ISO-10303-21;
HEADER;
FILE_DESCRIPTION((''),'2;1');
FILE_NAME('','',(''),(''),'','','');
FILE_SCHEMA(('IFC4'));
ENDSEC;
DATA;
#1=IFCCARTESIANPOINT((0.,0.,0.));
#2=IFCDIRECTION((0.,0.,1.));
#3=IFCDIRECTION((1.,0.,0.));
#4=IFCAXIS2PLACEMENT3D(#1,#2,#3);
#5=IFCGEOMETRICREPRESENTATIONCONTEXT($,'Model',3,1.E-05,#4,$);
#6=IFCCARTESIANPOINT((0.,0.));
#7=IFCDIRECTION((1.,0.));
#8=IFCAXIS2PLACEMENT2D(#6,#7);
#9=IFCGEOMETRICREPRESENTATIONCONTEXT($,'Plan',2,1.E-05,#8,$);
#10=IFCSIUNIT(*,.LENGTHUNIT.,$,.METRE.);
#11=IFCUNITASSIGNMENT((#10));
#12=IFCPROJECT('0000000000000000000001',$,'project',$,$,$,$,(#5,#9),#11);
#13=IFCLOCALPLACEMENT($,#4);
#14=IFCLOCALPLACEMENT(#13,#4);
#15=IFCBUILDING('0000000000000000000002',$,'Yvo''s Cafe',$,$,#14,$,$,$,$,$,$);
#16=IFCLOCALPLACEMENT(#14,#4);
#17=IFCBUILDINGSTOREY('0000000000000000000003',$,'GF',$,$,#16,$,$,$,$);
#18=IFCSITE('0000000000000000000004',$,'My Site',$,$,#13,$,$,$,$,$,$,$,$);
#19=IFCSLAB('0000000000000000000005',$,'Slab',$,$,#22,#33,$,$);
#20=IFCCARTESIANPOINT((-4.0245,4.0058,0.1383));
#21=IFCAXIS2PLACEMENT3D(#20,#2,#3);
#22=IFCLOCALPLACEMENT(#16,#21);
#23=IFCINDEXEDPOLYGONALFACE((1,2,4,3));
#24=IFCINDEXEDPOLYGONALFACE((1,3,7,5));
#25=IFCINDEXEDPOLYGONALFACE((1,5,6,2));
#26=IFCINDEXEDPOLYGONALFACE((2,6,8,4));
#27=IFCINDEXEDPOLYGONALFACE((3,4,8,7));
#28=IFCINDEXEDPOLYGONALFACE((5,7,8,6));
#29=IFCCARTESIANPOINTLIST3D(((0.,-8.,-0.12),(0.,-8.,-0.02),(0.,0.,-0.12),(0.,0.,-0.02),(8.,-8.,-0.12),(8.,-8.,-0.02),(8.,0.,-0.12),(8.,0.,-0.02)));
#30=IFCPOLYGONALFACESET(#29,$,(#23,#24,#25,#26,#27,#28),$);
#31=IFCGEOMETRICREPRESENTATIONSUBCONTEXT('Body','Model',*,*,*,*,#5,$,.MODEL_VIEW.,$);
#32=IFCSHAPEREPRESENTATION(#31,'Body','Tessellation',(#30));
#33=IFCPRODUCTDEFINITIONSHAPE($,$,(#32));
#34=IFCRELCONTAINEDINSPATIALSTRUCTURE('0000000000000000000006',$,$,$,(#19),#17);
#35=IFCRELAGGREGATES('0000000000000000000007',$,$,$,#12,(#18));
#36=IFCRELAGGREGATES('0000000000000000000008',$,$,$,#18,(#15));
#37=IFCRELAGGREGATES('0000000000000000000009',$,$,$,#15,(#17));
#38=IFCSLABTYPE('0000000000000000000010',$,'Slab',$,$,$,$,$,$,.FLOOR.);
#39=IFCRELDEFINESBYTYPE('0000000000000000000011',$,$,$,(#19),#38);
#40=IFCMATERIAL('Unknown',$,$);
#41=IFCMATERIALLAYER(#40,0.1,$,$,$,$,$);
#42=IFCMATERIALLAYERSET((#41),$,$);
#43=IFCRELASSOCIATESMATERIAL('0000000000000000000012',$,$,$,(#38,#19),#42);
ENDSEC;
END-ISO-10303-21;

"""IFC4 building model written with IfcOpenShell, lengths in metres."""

from ifc_helpers import new_model, si_unit, frame, origin_with_axes, origin_2d_with_axis, place, context, subcontext, project, spatial, indexed_curve, outline, extrude, material, layer, layer_set, layer_usage, type_object, element, save


model = new_model("IFC4")

# Units and contexts
model_context = context("Model", 3, precision=1e-05, world=origin_with_axes())
plan_context = context("Plan", 2, precision=1e-05, world=origin_2d_with_axis())
body_context_1 = subcontext(model_context, "Body", "Model", "MODEL_VIEW")
ifc_project = project(units=[si_unit("LENGTHUNIT", "METRE")], contexts=[model_context, plan_context])

# Site, building, storey
site_placement = place(None, origin_with_axes())
site = spatial("IfcSite", under=ifc_project, at=site_placement, Name="My Site")
building_placement = place(site_placement, origin_with_axes())
building = spatial("IfcBuilding", under=site, at=building_placement, Name="Yvo's Cafe")
storey_placement = place(building_placement, origin_with_axes())
storey = spatial("IfcBuildingStorey", under=building, at=storey_placement, Name="GF")

# Shared definitions
ifc_material = material(Name="Unknown")

# Slab
ifc_layer_1 = layer(ifc_material, 0.1)
ifc_layer_set_1 = layer_set([ifc_layer_1])
ifc_layer_usage_1 = layer_usage(ifc_layer_set_1, "AXIS3", "POSITIVE", -0.12)
slab_type = type_object("IfcSlabType", Name="Slab", PredefinedType="FLOOR", material=ifc_layer_set_1)
slab_placement = place(storey_placement, frame((-4.0245, 4.0058, 0.1383), z_axis=(0.0, 0.0, 1.0), x_axis=(1.0, 0.0, 0.0)))
element("IfcSlab", 1, at=slab_placement, inside=storey, type_object=slab_type, material=ifc_layer_usage_1, Name="Slab", context=body_context_1, shape_type="SweptSolid", body=[
    extrude(outline(indexed_curve([(0.0, 0.0), (0.0, -8.0), (8.0, -8.0), (8.0, 0.0), (0.0, 0.0)])), frame((0.0, 0.0, -0.12), z_axis=(0.0, 0.0, 1.0), x_axis=(1.0, 0.0, 0.0)), (0.0, 0.0, 1.0), 0.1),
])

save(model, "model.ifc")
